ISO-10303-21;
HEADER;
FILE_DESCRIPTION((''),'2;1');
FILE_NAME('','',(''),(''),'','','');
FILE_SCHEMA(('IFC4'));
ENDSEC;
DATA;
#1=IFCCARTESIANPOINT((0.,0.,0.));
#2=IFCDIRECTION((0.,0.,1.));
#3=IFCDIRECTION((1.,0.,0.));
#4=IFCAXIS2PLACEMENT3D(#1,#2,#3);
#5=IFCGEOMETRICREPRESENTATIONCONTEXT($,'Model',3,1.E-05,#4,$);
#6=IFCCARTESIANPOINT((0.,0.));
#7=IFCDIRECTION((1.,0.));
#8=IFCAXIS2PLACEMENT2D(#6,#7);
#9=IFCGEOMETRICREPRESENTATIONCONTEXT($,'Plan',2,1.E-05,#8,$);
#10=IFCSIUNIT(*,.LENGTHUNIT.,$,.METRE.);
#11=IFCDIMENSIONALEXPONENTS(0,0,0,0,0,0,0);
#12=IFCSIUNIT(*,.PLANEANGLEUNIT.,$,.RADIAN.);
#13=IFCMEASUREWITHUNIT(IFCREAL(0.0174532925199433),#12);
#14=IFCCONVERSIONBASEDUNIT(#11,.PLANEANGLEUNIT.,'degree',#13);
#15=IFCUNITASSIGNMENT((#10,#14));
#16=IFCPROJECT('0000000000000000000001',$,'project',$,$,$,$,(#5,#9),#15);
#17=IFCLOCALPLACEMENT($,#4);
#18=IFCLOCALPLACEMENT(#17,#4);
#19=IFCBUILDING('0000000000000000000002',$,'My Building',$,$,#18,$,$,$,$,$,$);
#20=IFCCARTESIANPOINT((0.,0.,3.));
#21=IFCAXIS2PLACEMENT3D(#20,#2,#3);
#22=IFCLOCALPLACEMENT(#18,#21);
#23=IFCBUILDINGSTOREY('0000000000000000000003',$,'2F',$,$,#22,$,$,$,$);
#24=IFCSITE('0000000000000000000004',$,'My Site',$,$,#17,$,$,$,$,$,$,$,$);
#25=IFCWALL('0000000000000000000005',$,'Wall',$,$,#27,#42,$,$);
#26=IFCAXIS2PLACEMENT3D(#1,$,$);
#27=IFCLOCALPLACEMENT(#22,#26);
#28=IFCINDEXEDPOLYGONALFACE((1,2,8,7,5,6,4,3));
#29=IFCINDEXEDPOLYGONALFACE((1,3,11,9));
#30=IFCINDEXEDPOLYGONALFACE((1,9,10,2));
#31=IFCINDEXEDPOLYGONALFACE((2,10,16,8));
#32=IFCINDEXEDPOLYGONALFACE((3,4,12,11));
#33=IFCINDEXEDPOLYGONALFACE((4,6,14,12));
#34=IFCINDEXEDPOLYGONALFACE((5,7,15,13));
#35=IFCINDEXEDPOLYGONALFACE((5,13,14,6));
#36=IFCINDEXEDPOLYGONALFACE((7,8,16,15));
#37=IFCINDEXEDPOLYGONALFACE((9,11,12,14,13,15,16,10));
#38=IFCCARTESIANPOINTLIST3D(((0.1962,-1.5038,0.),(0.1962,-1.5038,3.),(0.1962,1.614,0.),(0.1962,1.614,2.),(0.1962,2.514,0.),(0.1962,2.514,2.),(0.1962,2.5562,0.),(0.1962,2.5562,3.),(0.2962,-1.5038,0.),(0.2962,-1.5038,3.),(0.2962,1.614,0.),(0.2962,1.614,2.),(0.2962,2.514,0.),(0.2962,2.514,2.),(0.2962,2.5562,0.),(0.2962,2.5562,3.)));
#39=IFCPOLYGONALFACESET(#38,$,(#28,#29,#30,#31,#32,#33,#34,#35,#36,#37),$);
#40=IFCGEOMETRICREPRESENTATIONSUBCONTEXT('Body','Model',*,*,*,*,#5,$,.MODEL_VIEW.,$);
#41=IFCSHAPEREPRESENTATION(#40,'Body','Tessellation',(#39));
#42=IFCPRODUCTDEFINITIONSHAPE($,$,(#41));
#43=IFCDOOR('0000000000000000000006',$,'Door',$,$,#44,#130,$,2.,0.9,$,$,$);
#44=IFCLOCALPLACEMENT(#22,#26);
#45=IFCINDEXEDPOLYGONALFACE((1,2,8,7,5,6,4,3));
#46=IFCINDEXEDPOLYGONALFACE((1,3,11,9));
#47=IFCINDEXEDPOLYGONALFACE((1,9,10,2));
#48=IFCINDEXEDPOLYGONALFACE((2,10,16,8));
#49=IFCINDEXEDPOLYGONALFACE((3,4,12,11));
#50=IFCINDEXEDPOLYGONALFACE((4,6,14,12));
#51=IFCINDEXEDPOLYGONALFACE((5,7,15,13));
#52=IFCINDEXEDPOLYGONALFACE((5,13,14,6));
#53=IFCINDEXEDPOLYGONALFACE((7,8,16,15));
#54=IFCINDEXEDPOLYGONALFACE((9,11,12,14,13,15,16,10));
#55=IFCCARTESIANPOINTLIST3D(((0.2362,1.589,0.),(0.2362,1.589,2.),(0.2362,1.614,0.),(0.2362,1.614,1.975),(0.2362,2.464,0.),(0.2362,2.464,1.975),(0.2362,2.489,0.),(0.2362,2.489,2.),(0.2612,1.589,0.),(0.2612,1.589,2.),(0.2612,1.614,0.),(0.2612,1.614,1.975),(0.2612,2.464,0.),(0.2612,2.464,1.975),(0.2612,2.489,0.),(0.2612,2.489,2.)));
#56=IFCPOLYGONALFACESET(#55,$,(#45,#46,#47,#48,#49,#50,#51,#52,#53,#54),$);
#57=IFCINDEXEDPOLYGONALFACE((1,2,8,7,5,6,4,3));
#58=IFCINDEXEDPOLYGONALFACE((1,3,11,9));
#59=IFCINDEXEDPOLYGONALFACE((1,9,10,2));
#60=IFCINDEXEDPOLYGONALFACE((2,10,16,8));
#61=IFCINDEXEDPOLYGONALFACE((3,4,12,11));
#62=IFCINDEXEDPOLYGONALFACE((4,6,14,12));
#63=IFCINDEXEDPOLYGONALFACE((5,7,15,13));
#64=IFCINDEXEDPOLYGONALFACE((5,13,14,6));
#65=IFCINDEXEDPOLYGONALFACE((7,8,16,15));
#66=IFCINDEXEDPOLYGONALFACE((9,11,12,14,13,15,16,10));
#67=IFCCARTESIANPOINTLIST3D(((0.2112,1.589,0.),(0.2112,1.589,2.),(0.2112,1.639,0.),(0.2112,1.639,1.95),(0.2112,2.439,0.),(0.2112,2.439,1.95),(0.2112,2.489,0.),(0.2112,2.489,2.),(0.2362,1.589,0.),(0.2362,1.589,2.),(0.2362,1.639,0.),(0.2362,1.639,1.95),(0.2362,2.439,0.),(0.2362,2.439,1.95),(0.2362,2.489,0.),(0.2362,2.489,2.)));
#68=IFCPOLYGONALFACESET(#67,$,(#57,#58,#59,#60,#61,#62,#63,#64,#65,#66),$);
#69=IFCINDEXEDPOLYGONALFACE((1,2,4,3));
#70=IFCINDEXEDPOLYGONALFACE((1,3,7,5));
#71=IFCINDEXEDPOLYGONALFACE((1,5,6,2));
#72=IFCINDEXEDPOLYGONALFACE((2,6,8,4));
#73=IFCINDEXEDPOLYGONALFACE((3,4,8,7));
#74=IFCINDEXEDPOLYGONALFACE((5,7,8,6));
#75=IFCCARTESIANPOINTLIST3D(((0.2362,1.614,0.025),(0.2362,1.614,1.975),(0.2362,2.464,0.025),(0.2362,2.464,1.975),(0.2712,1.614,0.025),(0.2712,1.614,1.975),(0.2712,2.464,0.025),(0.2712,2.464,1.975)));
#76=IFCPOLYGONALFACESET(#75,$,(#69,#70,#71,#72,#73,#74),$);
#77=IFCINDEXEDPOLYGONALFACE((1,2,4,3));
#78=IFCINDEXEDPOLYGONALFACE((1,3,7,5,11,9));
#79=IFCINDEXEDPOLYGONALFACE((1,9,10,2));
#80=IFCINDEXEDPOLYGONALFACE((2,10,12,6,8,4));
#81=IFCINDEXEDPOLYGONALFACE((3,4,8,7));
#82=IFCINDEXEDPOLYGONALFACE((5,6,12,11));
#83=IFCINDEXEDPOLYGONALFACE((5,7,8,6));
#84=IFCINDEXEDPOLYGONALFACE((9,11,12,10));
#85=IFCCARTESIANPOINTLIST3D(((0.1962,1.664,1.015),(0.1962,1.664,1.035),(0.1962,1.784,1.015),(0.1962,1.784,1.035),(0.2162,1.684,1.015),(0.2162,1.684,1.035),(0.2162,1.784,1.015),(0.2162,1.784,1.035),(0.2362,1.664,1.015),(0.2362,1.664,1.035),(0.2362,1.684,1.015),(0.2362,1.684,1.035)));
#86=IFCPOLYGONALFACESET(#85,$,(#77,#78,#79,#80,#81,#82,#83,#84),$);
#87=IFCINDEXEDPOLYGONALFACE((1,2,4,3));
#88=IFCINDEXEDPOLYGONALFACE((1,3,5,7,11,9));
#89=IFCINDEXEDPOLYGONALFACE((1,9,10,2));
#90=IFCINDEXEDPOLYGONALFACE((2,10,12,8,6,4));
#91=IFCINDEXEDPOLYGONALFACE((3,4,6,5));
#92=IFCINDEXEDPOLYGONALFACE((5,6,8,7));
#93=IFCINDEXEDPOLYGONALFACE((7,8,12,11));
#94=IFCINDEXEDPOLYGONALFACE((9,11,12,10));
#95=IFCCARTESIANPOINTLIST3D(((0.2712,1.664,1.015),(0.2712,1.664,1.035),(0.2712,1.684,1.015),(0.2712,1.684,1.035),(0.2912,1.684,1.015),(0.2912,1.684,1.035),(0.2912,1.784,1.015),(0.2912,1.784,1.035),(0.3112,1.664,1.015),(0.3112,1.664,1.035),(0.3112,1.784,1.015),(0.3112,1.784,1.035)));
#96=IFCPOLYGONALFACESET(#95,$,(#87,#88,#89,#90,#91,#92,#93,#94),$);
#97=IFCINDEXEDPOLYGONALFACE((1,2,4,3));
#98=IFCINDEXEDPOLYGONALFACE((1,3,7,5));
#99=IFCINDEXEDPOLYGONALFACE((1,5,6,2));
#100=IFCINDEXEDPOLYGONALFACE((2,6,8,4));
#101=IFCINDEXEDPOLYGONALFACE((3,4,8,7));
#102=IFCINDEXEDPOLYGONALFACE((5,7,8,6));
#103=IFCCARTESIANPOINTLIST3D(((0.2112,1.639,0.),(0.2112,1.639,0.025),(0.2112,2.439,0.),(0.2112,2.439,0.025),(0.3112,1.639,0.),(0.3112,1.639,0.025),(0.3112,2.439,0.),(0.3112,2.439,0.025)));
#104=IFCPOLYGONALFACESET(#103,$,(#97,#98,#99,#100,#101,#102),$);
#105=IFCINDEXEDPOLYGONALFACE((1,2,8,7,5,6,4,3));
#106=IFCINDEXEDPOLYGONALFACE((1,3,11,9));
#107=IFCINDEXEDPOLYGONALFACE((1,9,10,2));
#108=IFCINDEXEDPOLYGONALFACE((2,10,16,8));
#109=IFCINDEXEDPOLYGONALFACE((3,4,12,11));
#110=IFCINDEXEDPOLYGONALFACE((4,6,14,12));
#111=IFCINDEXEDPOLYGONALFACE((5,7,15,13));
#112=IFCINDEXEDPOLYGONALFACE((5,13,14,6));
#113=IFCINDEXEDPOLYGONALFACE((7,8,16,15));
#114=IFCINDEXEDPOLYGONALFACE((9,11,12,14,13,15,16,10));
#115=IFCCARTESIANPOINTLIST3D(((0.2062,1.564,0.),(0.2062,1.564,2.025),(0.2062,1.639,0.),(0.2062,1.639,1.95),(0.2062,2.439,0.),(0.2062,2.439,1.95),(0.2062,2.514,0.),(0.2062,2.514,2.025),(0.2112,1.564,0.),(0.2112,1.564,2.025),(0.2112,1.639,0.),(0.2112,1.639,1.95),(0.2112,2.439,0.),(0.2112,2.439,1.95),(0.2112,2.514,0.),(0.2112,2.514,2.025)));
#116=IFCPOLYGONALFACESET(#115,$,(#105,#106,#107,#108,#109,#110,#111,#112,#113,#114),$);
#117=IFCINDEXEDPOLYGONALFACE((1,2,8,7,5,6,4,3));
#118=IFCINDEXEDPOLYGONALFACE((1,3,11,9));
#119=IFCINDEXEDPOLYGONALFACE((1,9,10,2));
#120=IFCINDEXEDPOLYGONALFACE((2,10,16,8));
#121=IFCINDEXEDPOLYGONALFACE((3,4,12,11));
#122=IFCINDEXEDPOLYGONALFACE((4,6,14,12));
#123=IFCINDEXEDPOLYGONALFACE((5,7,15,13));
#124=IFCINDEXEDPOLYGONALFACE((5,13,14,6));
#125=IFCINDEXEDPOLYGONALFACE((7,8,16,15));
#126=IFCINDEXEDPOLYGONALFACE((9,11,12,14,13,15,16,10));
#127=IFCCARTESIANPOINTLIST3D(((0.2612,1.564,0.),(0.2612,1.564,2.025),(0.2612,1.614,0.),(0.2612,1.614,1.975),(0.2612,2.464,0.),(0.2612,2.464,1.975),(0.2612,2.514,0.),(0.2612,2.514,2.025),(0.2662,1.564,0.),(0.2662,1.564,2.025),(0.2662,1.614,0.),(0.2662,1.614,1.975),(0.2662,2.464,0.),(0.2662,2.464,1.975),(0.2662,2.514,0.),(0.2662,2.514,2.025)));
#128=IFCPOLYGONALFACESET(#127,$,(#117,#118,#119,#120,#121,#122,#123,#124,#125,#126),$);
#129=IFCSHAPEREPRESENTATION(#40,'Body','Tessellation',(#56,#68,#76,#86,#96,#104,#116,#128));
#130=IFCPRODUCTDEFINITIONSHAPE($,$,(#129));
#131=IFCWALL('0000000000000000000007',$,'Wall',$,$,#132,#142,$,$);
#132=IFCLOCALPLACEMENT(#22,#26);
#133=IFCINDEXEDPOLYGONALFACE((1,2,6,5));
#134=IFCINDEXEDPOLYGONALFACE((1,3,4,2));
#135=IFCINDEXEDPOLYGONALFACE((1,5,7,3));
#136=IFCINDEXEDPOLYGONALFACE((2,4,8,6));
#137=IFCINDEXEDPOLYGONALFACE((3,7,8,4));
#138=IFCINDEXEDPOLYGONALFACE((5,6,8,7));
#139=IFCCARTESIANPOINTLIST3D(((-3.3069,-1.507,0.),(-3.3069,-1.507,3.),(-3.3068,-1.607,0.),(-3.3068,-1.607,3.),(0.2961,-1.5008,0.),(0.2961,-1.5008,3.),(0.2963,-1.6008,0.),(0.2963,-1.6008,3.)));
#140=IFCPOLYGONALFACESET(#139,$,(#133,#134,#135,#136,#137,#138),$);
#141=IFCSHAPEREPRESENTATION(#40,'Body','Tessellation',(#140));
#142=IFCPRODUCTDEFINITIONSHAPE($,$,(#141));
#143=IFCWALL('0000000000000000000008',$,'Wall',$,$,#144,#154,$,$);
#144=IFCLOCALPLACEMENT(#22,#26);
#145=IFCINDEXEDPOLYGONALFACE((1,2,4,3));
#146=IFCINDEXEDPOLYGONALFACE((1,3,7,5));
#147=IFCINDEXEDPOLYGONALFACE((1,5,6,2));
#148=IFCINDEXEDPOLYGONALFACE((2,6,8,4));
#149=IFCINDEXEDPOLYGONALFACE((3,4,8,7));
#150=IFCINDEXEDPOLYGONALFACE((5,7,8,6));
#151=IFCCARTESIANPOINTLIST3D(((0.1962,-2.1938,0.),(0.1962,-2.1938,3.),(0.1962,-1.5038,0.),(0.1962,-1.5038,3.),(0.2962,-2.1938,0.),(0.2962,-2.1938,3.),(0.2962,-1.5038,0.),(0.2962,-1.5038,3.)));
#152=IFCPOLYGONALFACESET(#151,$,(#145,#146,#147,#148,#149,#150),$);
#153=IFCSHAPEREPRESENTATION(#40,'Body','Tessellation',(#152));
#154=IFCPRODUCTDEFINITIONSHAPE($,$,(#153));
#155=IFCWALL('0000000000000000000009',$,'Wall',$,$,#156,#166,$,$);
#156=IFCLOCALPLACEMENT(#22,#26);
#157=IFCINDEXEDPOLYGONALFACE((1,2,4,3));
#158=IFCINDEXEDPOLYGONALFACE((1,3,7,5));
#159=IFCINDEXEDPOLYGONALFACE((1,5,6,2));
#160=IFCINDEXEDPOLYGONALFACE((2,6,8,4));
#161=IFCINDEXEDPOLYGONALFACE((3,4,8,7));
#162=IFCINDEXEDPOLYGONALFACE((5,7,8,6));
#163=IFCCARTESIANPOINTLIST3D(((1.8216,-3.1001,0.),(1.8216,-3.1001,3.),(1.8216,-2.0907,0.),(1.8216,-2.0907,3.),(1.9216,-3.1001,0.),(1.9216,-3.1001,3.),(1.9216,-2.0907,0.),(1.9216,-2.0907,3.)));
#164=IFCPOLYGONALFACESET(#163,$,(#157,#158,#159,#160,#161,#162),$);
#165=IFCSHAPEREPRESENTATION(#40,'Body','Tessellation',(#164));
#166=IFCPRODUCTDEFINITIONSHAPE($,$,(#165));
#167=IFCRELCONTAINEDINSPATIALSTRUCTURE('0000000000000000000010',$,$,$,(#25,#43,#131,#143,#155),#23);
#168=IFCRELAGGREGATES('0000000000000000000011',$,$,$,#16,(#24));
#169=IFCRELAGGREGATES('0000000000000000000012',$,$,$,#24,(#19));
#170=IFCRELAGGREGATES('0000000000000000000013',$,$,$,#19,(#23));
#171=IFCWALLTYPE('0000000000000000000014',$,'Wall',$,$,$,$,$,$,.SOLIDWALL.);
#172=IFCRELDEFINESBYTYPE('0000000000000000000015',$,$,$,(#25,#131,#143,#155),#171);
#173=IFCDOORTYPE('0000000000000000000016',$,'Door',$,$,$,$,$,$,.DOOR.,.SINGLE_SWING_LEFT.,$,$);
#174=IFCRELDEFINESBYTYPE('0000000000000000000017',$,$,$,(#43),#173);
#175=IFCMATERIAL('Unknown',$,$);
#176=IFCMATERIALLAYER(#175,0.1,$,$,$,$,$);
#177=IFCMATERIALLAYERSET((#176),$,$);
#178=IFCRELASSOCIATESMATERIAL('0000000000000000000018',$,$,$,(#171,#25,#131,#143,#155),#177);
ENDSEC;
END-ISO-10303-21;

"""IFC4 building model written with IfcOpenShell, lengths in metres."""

from ifc_helpers import new_model, entity, si_unit, converted_unit, frame, origin_with_axes, origin_2d_with_axis, place, context, subcontext, project, spatial, line, indexed_curve, outline, extrude, shape, source, transform, mapped, material, layer, layer_set, layer_usage, type_object, type_shapes, element, fill, save


model = new_model("IFC4")

# Units and contexts
model_context = context("Model", 3, precision=1e-05, world=origin_with_axes())
plan_context = context("Plan", 2, precision=1e-05, world=origin_2d_with_axis())
body_context_1 = subcontext(model_context, "Body", "Model", "MODEL_VIEW")
body_context_2 = subcontext(plan_context, "Body", "Plan", "PLAN_VIEW")
ifc_project = project(units=[si_unit("LENGTHUNIT", "METRE"), converted_unit("PLANEANGLEUNIT", "degree", entity("IfcReal", 0.0174532925199433), si_unit("PLANEANGLEUNIT", "RADIAN"), dimensions=[0, 0, 0, 0, 0, 0, 0])], contexts=[model_context, plan_context])

# Site, building, storey
site_placement = place(None, origin_with_axes())
site = spatial("IfcSite", under=ifc_project, at=site_placement, Name="My Site")
building_placement = place(site_placement, origin_with_axes())
building = spatial("IfcBuilding", under=site, at=building_placement, Name="My Building")
storey_placement = place(building_placement, frame((0.0, 0.0, 3.0), z_axis=(0.0, 0.0, 1.0), x_axis=(1.0, 0.0, 0.0)))
storey = spatial("IfcBuildingStorey", under=building, at=storey_placement, Name="2F")

# Shared definitions
ifc_material = material(Name="Unknown")

# Shared definitions
ifc_layer_1 = layer(ifc_material, 0.1)
ifc_layer_set_1 = layer_set([ifc_layer_1])
wall_type = type_object("IfcWallType", Name="Wall", PredefinedType="SOLIDWALL", material=ifc_layer_set_1)

# Wall, opening, door
ifc_layer_usage_1 = layer_usage(ifc_layer_set_1, "AXIS2", "POSITIVE", 0.0)
wall_1_placement = place(storey_placement, frame((0.2962, -1.5038, 0.0), z_axis=(0.0, 0.0, 1.0), x_axis=(0.0, 1.0, 0.0)))
wall_1 = element("IfcWall", 1, at=wall_1_placement, inside=storey, type_object=wall_type, material=ifc_layer_usage_1, Name="Wall", context=body_context_1, shape_type="SweptSolid", body=[
    extrude(outline(indexed_curve([(0.0, 0.0), (0.0, 0.1), (4.06, 0.1), (4.06, 0.0)], segments=[line(1, 2, 3, 4, 1)])), origin_with_axes(), (0.0, 0.0, 1.0), 3.0),
])
shared_shape_1 = source(origin_with_axes(), body_context_1, "Body", "SweptSolid", [
    extrude(outline(indexed_curve([(0.0, 0.0), (0.9, 0.0), (0.9, 2.0), (0.0, 2.0)], segments=[line(1, 2, 3, 4, 1)])), frame((0.0, -0.6, 0.0), z_axis=(0.0, -1.0, 0.0), x_axis=(1.0, 0.0, 0.0)), (0.0, 0.0, -1.0), 1.2),
])
opening_1_placement = place(wall_1_placement, frame((3.1178, 0.0, 0.0), z_axis=(0.0, 0.0, 1.0), x_axis=(1.0, 0.0, 0.0)))
opening_1 = element("IfcOpeningElement", 2, at=opening_1_placement, cuts=wall_1, PredefinedType="OPENING", context=body_context_1, shape_type="MappedRepresentation", body=[
    mapped(shared_shape_1, transform((0.0, 0.0, 0.0), x_axis=(1.0, 0.0, 0.0), y_axis=(0.0, 1.0, 0.0), z_axis=(0.0, 0.0, 1.0), scale=1.0)),
])
door_type_1 = type_object("IfcDoorType", Name="Door", OperationType="SINGLE_SWING_LEFT", PredefinedType="DOOR")
shared_shape_2 = source(origin_with_axes(), body_context_1, "Body", "SweptSolid", [
    extrude(outline(indexed_curve([(0.0, 0.0), (0.0, 2.0), (0.9, 2.0), (0.9, 0.0), (0.875, 0.0), (0.875, 1.975), (0.025, 1.975), (0.025, 0.0)], segments=[line(1, 2, 3, 4, 5, 6, 7, 8, 1)])), frame((0.0, 0.025, 0.0), z_axis=(0.0, -1.0, 0.0), x_axis=(1.0, 0.0, 0.0)), (0.0, 0.0, -1.0), 0.025),
    extrude(outline(indexed_curve([(0.0, 0.0), (0.0, 2.0), (0.9, 2.0), (0.9, 0.0), (0.85, 0.0), (0.85, 1.95), (0.05, 1.95), (0.05, 0.0)], segments=[line(1, 2, 3, 4, 5, 6, 7, 8, 1)])), frame((0.0, 0.0, 0.0), z_axis=(0.0, -1.0, 0.0), x_axis=(1.0, 0.0, 0.0)), (0.0, 0.0, -1.0), 0.025),
    extrude(outline(indexed_curve([(0.0, 0.0), (0.85, 0.0), (0.85, 0.035), (0.0, 0.035)], segments=[line(1, 2, 3, 4, 1)])), frame((0.025, 0.025, 0.025), z_axis=(0.0, 0.0, 1.0), x_axis=(1.0, 0.0, 0.0)), (0.0, 0.0, 1.0), 1.95),
    extrude(outline(indexed_curve([(0.0, 0.0), (0.0, -0.04), (-0.12, -0.04), (-0.12, -0.02), (-0.02, -0.02), (-0.02, 0.0)], segments=[line(1, 2, 3, 4, 5, 6, 1)])), frame((0.825, 0.025, 1.015), z_axis=(0.0, 0.0, 1.0), x_axis=(1.0, 0.0, 0.0)), (0.0, 0.0, 1.0), 0.02),
    extrude(outline(indexed_curve([(0.0, 0.0), (0.0, 0.04), (-0.12, 0.04), (-0.12, 0.02), (-0.02, 0.02), (-0.02, 0.0)], segments=[line(1, 2, 3, 4, 5, 6, 1)])), frame((0.825, 0.06, 1.015), z_axis=(0.0, 0.0, 1.0), x_axis=(1.0, 0.0, 0.0)), (0.0, 0.0, 1.0), 0.02),
    extrude(outline(indexed_curve([(0.0, 0.0), (0.8, 0.0), (0.8, 0.1), (0.0, 0.1)], segments=[line(1, 2, 3, 4, 1)])), frame((0.05, 0.0, 0.0), z_axis=(0.0, 0.0, 1.0), x_axis=(1.0, 0.0, 0.0)), (0.0, 0.0, 1.0), 0.025),
    extrude(outline(indexed_curve([(0.0, 0.0), (0.0, 2.025), (0.95, 2.025), (0.95, 0.0), (0.875, 0.0), (0.875, 1.95), (0.075, 1.95), (0.075, 0.0)], segments=[line(1, 2, 3, 4, 5, 6, 7, 8, 1)])), frame((-0.025, -0.005, 0.0), z_axis=(0.0, -1.0, 0.0), x_axis=(1.0, 0.0, 0.0)), (0.0, 0.0, -1.0), 0.005),
    extrude(outline(indexed_curve([(0.0, 0.0), (0.0, 2.025), (0.95, 2.025), (0.95, 0.0), (0.9, 0.0), (0.9, 1.975), (0.05, 1.975), (0.05, 0.0)], segments=[line(1, 2, 3, 4, 5, 6, 7, 8, 1)])), frame((-0.025, 0.05, 0.0), z_axis=(0.0, -1.0, 0.0), x_axis=(1.0, 0.0, 0.0)), (0.0, 0.0, -1.0), 0.005),
])
shared_shape_3 = source(origin_with_axes(), body_context_2, "Body", "Curve2D", [
    entity("IfcIndexedPolyCurve", entity("IfcCartesianPointList2D", [[0.0, 0.0], [0.0, 0.05], [0.025, 0.05], [0.025, 0.025], [0.05, 0.025], [0.05, 0.0]]), [entity("IfcLineIndex", [1, 2, 3, 4, 5, 6, 1])]),
    entity("IfcIndexedPolyCurve", entity("IfcCartesianPointList2D", [[0.9, 0.0], [0.9, 0.05], [0.875, 0.05], [0.875, 0.025], [0.85, 0.025], [0.85, 0.0]]), [entity("IfcLineIndex", [1, 2, 3, 4, 5, 6, 1])]),
    entity("IfcTrimmedCurve", entity("IfcEllipse", entity("IfcAxis2Placement2D", entity("IfcCartesianPoint", [0.06, 0.05]), entity("IfcDirection", [1.0, 0.0])), 0.815, 0.85), [entity("IfcCartesianPoint", [0.875, 0.05])], [entity("IfcCartesianPoint", [0.06, 0.9])], True, "CARTESIAN"),
    entity("IfcIndexedPolyCurve", entity("IfcCartesianPointList2D", [[0.025, 0.05], [0.06, 0.05], [0.06, 0.9], [0.025, 0.9]]), [entity("IfcLineIndex", [1, 2, 3, 4, 1])]),
])
type_shapes(door_type_1, [shared_shape_2, shared_shape_3])
door_1_placement = place(opening_1_placement, frame((0.875, 0.085, 0.0), z_axis=(0.0, 0.0, 1.0), x_axis=(-1.0, 0.0, 0.0)))
door_1 = element("IfcDoor", 3, at=door_1_placement, inside=storey, type_object=door_type_1, Name="Door", OverallHeight=2.0, OverallWidth=0.9, shapes=[
    shape(body_context_1, "Body", "MappedRepresentation", [mapped(shared_shape_2, transform((0.0, 0.0, 0.0), x_axis=(1.0, 0.0, 0.0), y_axis=(0.0, 1.0, 0.0), z_axis=(0.0, 0.0, 1.0), scale=1.0))]),
    shape(body_context_2, "Body", "MappedRepresentation", [mapped(shared_shape_3, transform((0.0, 0.0, 0.0), x_axis=(1.0, 0.0, 0.0), y_axis=(0.0, 1.0, 0.0), z_axis=(0.0, 0.0, 1.0), scale=1.0))]),
])
fill(opening_1, door_1)

# Walls
ifc_layer_usage_2 = layer_usage(ifc_layer_set_1, "AXIS2", "POSITIVE", 0.0)
wall_2_placement = place(storey_placement, frame((-3.3068, -1.607, 0.0), z_axis=(0.0, 0.0, 1.0), x_axis=(0.999999, 0.001712, 0.0)))
element("IfcWall", 4, at=wall_2_placement, inside=storey, type_object=wall_type, material=ifc_layer_usage_2, Name="Wall", context=body_context_1, shape_type="SweptSolid", body=[
    extrude(outline(indexed_curve([(0.0, 0.0), (0.0, 0.1), (3.6031, 0.1), (3.6031, 0.0)], segments=[line(1, 2, 3, 4, 1)])), origin_with_axes(), (0.0, 0.0, 1.0), 3.0),
])
ifc_layer_usage_3 = layer_usage(ifc_layer_set_1, "AXIS2", "POSITIVE", 0.0)
wall_3_placement = place(storey_placement, frame((0.1962, -1.5038, 0.0), z_axis=(0.0, 0.0, 1.0), x_axis=(0.0, -1.0, 0.0)))
element("IfcWall", 5, at=wall_3_placement, inside=storey, type_object=wall_type, material=ifc_layer_usage_3, Name="Wall", context=body_context_1, shape_type="SweptSolid", body=[
    extrude(outline(indexed_curve([(0.0, 0.0), (0.0, 0.1), (0.69, 0.1), (0.69, 0.0)], segments=[line(1, 2, 3, 4, 1)])), origin_with_axes(), (0.0, 0.0, 1.0), 3.0),
])
ifc_layer_usage_4 = layer_usage(ifc_layer_set_1, "AXIS2", "POSITIVE", 0.0)
wall_4_placement = place(storey_placement, frame((1.9216, -3.1001, 0.0), z_axis=(0.0, 0.0, 1.0), x_axis=(0.000002, 1.0, 0.0)))
element("IfcWall", 6, at=wall_4_placement, inside=storey, type_object=wall_type, material=ifc_layer_usage_4, Name="Wall", context=body_context_1, shape_type="SweptSolid", body=[
    extrude(outline(indexed_curve([(0.0, 0.0), (0.0, 0.1), (1.0094, 0.1), (1.0094, 0.0)], segments=[line(1, 2, 3, 4, 1)])), origin_with_axes(), (0.0, 0.0, 1.0), 3.0),
])

save(model, "model.ifc")
